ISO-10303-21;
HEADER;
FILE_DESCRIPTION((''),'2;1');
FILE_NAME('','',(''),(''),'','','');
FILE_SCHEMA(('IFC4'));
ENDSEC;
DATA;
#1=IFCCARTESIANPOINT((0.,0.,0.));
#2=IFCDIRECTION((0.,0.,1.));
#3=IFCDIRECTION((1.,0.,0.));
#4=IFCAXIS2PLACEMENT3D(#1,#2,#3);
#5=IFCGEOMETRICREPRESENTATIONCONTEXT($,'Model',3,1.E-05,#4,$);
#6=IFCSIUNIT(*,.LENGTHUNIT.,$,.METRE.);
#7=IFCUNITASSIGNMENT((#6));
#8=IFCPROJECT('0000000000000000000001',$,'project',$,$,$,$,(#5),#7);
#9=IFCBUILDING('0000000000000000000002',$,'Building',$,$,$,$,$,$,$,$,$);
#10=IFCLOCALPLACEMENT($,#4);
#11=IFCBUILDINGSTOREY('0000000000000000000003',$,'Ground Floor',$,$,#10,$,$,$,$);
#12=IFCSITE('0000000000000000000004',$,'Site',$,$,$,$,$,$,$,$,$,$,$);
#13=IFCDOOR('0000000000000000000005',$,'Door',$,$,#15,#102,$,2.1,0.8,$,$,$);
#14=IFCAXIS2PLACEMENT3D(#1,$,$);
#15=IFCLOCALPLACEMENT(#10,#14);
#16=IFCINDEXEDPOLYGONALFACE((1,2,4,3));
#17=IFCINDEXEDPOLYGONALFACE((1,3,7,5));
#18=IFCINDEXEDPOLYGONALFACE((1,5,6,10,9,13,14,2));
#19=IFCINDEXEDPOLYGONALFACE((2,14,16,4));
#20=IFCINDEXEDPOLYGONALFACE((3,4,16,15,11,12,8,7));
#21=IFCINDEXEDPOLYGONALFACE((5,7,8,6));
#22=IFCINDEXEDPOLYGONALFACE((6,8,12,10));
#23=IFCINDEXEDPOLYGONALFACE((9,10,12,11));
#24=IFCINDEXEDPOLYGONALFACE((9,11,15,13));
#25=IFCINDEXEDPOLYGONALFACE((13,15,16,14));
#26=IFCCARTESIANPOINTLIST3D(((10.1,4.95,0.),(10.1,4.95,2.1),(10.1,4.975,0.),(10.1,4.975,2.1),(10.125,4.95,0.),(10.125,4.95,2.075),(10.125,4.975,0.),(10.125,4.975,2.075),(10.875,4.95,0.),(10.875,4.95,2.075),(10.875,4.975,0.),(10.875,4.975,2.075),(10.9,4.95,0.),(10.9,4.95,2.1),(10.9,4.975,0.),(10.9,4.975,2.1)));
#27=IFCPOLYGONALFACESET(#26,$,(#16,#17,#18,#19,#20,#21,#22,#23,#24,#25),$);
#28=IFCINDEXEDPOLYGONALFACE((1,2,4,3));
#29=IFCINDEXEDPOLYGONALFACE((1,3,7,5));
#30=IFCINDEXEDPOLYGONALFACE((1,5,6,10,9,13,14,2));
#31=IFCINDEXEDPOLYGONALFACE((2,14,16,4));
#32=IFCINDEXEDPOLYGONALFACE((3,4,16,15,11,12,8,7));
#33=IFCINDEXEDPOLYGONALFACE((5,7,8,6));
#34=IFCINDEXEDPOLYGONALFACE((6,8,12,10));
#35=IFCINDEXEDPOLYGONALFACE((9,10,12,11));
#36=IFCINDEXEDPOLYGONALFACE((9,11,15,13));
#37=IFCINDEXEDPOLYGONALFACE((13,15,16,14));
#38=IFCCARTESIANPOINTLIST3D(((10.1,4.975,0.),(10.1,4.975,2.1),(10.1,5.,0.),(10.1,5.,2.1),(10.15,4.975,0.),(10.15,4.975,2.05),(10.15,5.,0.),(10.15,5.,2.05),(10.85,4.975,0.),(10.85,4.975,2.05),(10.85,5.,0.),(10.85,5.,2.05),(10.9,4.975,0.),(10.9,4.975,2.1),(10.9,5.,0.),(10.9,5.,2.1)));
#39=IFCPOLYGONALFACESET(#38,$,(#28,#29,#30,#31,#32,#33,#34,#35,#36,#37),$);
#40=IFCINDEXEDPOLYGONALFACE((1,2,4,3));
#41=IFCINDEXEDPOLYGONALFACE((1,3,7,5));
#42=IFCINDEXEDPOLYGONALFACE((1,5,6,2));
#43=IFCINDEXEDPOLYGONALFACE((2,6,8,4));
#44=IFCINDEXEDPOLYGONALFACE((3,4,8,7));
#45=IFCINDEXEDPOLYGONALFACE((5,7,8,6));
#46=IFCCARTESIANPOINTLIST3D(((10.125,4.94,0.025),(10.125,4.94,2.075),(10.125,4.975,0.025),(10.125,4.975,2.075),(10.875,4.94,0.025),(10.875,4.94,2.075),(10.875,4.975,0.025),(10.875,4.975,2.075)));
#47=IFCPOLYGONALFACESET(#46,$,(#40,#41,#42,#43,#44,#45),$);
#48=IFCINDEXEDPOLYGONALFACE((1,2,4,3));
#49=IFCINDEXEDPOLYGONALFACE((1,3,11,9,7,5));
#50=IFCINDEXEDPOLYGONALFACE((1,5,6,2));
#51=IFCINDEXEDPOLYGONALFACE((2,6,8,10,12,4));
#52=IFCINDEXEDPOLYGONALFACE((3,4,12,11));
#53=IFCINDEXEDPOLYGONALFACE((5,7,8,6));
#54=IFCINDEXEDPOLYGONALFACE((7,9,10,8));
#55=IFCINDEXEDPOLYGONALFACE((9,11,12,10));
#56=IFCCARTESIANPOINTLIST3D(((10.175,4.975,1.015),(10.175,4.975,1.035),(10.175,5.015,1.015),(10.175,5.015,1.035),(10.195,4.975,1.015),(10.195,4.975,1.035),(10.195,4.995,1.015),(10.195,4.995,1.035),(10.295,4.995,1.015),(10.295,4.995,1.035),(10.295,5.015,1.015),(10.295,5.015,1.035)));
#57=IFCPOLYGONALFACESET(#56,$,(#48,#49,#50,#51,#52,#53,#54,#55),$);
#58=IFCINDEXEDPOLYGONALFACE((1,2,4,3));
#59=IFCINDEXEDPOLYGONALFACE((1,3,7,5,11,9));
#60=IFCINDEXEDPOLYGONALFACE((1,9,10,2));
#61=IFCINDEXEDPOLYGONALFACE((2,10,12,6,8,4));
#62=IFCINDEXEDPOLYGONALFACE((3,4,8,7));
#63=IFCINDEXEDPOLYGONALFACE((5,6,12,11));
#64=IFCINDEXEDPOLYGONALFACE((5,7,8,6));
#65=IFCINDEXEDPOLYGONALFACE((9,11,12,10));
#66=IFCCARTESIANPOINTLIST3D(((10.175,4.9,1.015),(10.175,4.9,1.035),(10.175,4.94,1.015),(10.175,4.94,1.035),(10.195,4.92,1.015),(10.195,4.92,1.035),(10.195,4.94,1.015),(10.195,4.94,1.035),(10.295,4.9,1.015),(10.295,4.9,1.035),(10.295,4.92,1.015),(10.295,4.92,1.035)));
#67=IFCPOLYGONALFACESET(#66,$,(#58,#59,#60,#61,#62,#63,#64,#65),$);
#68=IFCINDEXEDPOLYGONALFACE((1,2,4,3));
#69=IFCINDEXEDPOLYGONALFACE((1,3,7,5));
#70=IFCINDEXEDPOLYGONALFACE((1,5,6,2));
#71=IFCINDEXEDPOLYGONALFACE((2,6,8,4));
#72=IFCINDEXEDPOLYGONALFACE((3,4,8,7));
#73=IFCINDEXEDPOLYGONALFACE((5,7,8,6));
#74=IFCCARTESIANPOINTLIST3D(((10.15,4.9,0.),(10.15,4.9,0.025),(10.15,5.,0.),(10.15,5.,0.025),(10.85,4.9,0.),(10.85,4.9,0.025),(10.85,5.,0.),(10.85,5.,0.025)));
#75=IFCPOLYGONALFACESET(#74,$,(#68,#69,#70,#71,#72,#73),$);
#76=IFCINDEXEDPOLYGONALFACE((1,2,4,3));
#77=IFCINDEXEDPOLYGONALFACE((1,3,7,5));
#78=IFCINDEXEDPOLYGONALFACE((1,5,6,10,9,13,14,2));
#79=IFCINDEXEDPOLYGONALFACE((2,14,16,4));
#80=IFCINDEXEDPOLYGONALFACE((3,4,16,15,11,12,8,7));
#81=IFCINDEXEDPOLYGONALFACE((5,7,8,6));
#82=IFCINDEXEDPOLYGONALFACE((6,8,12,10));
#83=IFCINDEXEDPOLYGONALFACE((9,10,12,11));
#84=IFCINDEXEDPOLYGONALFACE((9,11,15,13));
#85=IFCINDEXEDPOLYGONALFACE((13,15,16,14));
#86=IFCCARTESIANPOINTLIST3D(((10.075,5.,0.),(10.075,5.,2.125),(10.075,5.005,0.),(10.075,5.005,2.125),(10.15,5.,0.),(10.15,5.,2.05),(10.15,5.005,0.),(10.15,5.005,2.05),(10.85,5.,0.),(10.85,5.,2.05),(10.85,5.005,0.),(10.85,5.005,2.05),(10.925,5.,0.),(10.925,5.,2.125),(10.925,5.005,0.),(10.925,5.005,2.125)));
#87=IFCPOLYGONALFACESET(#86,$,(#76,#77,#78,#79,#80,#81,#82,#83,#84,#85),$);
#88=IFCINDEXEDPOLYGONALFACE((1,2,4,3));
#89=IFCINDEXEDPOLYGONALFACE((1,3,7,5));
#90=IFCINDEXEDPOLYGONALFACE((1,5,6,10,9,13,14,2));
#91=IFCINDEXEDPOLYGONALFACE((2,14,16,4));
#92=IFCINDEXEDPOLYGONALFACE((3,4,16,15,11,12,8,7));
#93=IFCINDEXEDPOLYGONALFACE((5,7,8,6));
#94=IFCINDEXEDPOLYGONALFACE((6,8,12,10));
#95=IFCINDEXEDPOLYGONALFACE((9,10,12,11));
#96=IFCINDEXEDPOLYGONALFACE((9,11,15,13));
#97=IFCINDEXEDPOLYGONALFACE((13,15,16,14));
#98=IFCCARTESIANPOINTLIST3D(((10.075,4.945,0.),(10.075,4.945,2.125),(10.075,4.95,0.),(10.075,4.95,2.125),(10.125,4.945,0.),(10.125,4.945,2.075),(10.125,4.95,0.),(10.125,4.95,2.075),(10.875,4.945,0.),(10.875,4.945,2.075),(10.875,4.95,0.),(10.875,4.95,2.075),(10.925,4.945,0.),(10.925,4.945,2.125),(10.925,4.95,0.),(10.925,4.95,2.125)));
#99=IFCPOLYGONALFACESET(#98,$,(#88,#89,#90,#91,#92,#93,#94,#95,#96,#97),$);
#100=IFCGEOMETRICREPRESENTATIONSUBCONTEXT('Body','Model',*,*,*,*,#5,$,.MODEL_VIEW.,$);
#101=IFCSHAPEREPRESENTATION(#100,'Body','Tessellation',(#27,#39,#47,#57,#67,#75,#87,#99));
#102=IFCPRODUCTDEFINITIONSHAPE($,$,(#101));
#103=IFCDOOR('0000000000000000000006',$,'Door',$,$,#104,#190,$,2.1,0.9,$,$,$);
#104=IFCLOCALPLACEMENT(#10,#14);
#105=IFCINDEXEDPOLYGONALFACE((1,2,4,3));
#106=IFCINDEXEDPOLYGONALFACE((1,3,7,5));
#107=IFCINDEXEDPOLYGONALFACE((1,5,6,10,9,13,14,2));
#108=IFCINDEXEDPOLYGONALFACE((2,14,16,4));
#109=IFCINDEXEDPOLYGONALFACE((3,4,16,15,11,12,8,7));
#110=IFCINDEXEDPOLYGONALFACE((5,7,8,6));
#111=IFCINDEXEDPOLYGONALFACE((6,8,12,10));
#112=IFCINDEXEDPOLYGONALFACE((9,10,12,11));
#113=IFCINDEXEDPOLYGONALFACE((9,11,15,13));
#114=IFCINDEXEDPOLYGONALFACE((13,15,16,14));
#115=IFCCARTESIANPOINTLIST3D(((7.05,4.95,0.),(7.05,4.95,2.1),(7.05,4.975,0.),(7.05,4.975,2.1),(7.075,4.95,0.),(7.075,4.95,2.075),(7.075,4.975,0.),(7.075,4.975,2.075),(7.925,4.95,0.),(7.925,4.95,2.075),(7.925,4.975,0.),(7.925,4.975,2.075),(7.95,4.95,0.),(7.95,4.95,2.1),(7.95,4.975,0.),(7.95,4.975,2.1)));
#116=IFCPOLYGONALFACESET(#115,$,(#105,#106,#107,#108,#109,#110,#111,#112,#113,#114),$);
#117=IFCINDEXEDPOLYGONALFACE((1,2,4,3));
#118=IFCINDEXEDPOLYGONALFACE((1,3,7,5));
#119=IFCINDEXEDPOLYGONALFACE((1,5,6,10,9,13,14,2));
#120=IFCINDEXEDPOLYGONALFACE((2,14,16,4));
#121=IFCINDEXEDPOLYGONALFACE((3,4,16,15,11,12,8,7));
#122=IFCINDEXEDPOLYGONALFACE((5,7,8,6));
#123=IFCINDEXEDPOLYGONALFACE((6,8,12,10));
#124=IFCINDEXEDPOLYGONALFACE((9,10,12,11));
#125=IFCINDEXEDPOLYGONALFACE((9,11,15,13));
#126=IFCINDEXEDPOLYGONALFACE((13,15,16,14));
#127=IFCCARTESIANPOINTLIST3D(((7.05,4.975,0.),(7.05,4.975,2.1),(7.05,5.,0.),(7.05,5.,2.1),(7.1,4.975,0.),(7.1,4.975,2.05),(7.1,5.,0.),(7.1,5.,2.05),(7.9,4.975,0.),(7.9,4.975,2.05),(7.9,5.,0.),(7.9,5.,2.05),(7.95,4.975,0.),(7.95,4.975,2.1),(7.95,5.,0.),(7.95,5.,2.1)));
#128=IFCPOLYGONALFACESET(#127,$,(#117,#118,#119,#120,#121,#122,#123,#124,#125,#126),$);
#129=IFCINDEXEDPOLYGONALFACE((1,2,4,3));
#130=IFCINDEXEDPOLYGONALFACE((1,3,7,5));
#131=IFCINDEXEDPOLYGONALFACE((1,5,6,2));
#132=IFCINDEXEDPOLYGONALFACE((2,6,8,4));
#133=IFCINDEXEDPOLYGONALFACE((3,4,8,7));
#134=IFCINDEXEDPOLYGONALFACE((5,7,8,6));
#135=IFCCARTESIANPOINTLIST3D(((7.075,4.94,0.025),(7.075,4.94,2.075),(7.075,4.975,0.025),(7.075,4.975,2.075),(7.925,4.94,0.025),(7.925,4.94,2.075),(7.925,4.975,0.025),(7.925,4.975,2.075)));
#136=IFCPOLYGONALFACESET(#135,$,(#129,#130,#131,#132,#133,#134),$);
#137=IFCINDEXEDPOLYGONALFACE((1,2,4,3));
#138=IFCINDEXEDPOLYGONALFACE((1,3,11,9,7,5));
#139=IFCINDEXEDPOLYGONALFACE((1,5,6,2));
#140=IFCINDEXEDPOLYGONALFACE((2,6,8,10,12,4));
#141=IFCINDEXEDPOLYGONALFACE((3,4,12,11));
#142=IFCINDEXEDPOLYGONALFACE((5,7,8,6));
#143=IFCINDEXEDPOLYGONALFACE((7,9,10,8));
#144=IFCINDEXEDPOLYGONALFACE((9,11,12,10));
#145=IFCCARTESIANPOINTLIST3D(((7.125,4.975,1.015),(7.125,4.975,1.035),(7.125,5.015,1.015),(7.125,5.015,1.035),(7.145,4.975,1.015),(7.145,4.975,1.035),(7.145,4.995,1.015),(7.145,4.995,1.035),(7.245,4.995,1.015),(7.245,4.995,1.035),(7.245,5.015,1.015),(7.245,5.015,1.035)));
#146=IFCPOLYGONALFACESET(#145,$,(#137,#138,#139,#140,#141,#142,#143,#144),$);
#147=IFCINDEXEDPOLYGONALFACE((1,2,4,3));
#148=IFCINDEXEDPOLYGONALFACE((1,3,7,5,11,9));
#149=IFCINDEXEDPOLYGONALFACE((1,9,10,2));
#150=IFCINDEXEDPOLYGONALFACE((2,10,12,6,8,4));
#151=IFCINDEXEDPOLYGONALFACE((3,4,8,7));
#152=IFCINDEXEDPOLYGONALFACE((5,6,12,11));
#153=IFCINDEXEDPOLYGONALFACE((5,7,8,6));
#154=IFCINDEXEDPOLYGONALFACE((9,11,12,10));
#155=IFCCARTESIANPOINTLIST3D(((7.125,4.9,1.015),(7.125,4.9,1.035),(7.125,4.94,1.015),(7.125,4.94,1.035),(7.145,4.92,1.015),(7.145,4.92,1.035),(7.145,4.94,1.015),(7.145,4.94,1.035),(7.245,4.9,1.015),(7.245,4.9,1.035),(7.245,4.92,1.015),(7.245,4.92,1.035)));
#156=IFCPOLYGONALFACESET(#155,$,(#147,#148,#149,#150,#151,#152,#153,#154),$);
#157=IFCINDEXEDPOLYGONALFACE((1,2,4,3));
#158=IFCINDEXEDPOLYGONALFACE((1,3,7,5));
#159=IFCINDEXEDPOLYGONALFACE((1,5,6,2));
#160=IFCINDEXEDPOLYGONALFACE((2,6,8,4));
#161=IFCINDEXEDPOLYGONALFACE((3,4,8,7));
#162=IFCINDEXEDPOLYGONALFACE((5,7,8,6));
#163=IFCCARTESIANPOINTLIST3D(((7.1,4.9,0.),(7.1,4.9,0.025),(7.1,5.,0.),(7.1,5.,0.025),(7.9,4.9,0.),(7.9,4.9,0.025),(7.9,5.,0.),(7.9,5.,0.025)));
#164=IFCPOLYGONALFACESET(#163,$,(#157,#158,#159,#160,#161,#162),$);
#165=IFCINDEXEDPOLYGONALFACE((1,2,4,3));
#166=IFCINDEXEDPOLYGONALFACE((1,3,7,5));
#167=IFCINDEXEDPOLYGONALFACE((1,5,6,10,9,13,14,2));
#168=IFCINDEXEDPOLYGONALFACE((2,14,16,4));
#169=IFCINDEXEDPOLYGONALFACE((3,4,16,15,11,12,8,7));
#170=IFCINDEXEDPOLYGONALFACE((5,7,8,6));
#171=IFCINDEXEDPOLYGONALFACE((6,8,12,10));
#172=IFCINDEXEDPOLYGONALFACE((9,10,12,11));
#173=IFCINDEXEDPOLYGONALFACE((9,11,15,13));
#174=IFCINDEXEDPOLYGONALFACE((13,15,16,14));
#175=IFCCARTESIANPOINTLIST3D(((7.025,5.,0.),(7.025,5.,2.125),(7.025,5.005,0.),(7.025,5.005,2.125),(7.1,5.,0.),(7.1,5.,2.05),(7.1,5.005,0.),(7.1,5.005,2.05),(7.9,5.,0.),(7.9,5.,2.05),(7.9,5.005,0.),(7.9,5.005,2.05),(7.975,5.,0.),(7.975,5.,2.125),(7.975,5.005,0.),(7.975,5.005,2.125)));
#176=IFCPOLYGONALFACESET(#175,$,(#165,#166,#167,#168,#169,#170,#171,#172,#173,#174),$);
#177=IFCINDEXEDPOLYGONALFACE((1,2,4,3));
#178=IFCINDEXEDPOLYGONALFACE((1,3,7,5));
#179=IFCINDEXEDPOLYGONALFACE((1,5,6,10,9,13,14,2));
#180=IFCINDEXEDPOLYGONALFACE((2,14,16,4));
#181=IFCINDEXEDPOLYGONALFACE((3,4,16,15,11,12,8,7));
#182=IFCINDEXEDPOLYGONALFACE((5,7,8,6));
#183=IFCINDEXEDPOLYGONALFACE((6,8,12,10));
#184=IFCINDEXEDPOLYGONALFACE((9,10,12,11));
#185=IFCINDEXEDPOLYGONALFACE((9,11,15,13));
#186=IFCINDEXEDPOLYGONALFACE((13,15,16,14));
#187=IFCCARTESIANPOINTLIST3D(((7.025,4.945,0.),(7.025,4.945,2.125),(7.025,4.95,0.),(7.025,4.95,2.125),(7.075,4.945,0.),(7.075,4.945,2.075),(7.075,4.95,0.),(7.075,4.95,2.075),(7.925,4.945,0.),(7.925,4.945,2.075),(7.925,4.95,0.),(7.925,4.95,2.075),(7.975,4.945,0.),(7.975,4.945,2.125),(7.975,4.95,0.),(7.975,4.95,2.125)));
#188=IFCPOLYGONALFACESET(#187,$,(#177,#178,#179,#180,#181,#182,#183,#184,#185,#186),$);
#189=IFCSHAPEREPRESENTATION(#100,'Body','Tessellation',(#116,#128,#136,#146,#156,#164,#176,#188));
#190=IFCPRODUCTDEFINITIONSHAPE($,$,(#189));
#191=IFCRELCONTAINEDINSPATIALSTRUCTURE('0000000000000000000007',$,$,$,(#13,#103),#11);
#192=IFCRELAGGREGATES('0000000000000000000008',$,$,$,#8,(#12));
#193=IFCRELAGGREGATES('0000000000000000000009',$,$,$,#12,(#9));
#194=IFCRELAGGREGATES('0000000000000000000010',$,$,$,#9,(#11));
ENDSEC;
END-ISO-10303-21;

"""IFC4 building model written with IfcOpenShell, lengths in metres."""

from ifc_helpers import new_model, si_unit, frame, origin_with_axes, place, context, subcontext, project, spatial, line, indexed_curve, outline, extrude, element, save


model = new_model("IFC4")

# Units and contexts
model_context = context("Model", 3, precision=1e-05, world=origin_with_axes())
body_context = subcontext(model_context, "Body", "Model", "MODEL_VIEW")
ifc_project = project(units=[si_unit("LENGTHUNIT", "METRE")], contexts=[model_context])

# Site, building, storey
site = spatial("IfcSite", under=ifc_project, Name="Site")
building = spatial("IfcBuilding", under=site, Name="Building")
storey_placement = place(None, origin_with_axes())
storey = spatial("IfcBuildingStorey", under=building, at=storey_placement, Name="Ground Floor")

# Doors
door_1_placement = place(storey_placement, frame((10.9, 5.0, 0.0), z_axis=(0.0, 0.0, 1.0), x_axis=(-1.0, 0.0, 0.0)))
element("IfcDoor", 1, at=door_1_placement, inside=storey, Name="Door", OverallHeight=2.1, OverallWidth=0.8, context=body_context, shape_type="SweptSolid", body=[
    extrude(outline(indexed_curve([(0.0, 0.0), (0.0, 2.1), (0.8, 2.1), (0.8, 0.0), (0.775, 0.0), (0.775, 2.075), (0.025, 2.075), (0.025, 0.0)], segments=[line(1, 2, 3, 4, 5, 6, 7, 8, 1)])), frame((0.0, 0.025, 0.0), z_axis=(0.0, -1.0, 0.0), x_axis=(1.0, 0.0, 0.0)), (0.0, 0.0, -1.0), 0.025),
    extrude(outline(indexed_curve([(0.0, 0.0), (0.0, 2.1), (0.8, 2.1), (0.8, 0.0), (0.75, 0.0), (0.75, 2.05), (0.05, 2.05), (0.05, 0.0)], segments=[line(1, 2, 3, 4, 5, 6, 7, 8, 1)])), frame((0.0, 0.0, 0.0), z_axis=(0.0, -1.0, 0.0), x_axis=(1.0, 0.0, 0.0)), (0.0, 0.0, -1.0), 0.025),
    extrude(outline(indexed_curve([(0.0, 0.0), (0.75, 0.0), (0.75, 0.035), (0.0, 0.035)], segments=[line(1, 2, 3, 4, 1)])), frame((0.025, 0.025, 0.025), z_axis=(0.0, 0.0, 1.0), x_axis=(1.0, 0.0, 0.0)), (0.0, 0.0, 1.0), 2.05),
    extrude(outline(indexed_curve([(0.0, 0.0), (0.0, -0.04), (-0.12, -0.04), (-0.12, -0.02), (-0.02, -0.02), (-0.02, 0.0)], segments=[line(1, 2, 3, 4, 5, 6, 1)])), frame((0.725, 0.025, 1.015), z_axis=(0.0, 0.0, 1.0), x_axis=(1.0, 0.0, 0.0)), (0.0, 0.0, 1.0), 0.02),
    extrude(outline(indexed_curve([(0.0, 0.0), (0.0, 0.04), (-0.12, 0.04), (-0.12, 0.02), (-0.02, 0.02), (-0.02, 0.0)], segments=[line(1, 2, 3, 4, 5, 6, 1)])), frame((0.725, 0.06, 1.015), z_axis=(0.0, 0.0, 1.0), x_axis=(1.0, 0.0, 0.0)), (0.0, 0.0, 1.0), 0.02),
    extrude(outline(indexed_curve([(0.0, 0.0), (0.7, 0.0), (0.7, 0.1), (0.0, 0.1)], segments=[line(1, 2, 3, 4, 1)])), frame((0.05, 0.0, 0.0), z_axis=(0.0, 0.0, 1.0), x_axis=(1.0, 0.0, 0.0)), (0.0, 0.0, 1.0), 0.025),
    extrude(outline(indexed_curve([(0.0, 0.0), (0.0, 2.125), (0.85, 2.125), (0.85, 0.0), (0.775, 0.0), (0.775, 2.05), (0.075, 2.05), (0.075, 0.0)], segments=[line(1, 2, 3, 4, 5, 6, 7, 8, 1)])), frame((-0.025, -0.005, 0.0), z_axis=(0.0, -1.0, 0.0), x_axis=(1.0, 0.0, 0.0)), (0.0, 0.0, -1.0), 0.005),
    extrude(outline(indexed_curve([(0.0, 0.0), (0.0, 2.125), (0.85, 2.125), (0.85, 0.0), (0.8, 0.0), (0.8, 2.075), (0.05, 2.075), (0.05, 0.0)], segments=[line(1, 2, 3, 4, 5, 6, 7, 8, 1)])), frame((-0.025, 0.05, 0.0), z_axis=(0.0, -1.0, 0.0), x_axis=(1.0, 0.0, 0.0)), (0.0, 0.0, -1.0), 0.005),
])
door_2_placement = place(storey_placement, frame((7.95, 5.0, 0.0), z_axis=(0.0, 0.0, 1.0), x_axis=(-1.0, 0.0, 0.0)))
element("IfcDoor", 2, at=door_2_placement, inside=storey, Name="Door", OverallHeight=2.1, OverallWidth=0.9, context=body_context, shape_type="SweptSolid", body=[
    extrude(outline(indexed_curve([(0.0, 0.0), (0.0, 2.1), (0.9, 2.1), (0.9, 0.0), (0.875, 0.0), (0.875, 2.075), (0.025, 2.075), (0.025, 0.0)], segments=[line(1, 2, 3, 4, 5, 6, 7, 8, 1)])), frame((0.0, 0.025, 0.0), z_axis=(0.0, -1.0, 0.0), x_axis=(1.0, 0.0, 0.0)), (0.0, 0.0, -1.0), 0.025),
    extrude(outline(indexed_curve([(0.0, 0.0), (0.0, 2.1), (0.9, 2.1), (0.9, 0.0), (0.85, 0.0), (0.85, 2.05), (0.05, 2.05), (0.05, 0.0)], segments=[line(1, 2, 3, 4, 5, 6, 7, 8, 1)])), frame((0.0, 0.0, 0.0), z_axis=(0.0, -1.0, 0.0), x_axis=(1.0, 0.0, 0.0)), (0.0, 0.0, -1.0), 0.025),
    extrude(outline(indexed_curve([(0.0, 0.0), (0.85, 0.0), (0.85, 0.035), (0.0, 0.035)], segments=[line(1, 2, 3, 4, 1)])), frame((0.025, 0.025, 0.025), z_axis=(0.0, 0.0, 1.0), x_axis=(1.0, 0.0, 0.0)), (0.0, 0.0, 1.0), 2.05),
    extrude(outline(indexed_curve([(0.0, 0.0), (0.0, -0.04), (-0.12, -0.04), (-0.12, -0.02), (-0.02, -0.02), (-0.02, 0.0)], segments=[line(1, 2, 3, 4, 5, 6, 1)])), frame((0.825, 0.025, 1.015), z_axis=(0.0, 0.0, 1.0), x_axis=(1.0, 0.0, 0.0)), (0.0, 0.0, 1.0), 0.02),
    extrude(outline(indexed_curve([(0.0, 0.0), (0.0, 0.04), (-0.12, 0.04), (-0.12, 0.02), (-0.02, 0.02), (-0.02, 0.0)], segments=[line(1, 2, 3, 4, 5, 6, 1)])), frame((0.825, 0.06, 1.015), z_axis=(0.0, 0.0, 1.0), x_axis=(1.0, 0.0, 0.0)), (0.0, 0.0, 1.0), 0.02),
    extrude(outline(indexed_curve([(0.0, 0.0), (0.8, 0.0), (0.8, 0.1), (0.0, 0.1)], segments=[line(1, 2, 3, 4, 1)])), frame((0.05, 0.0, 0.0), z_axis=(0.0, 0.0, 1.0), x_axis=(1.0, 0.0, 0.0)), (0.0, 0.0, 1.0), 0.025),
    extrude(outline(indexed_curve([(0.0, 0.0), (0.0, 2.125), (0.95, 2.125), (0.95, 0.0), (0.875, 0.0), (0.875, 2.05), (0.075, 2.05), (0.075, 0.0)], segments=[line(1, 2, 3, 4, 5, 6, 7, 8, 1)])), frame((-0.025, -0.005, 0.0), z_axis=(0.0, -1.0, 0.0), x_axis=(1.0, 0.0, 0.0)), (0.0, 0.0, -1.0), 0.005),
    extrude(outline(indexed_curve([(0.0, 0.0), (0.0, 2.125), (0.95, 2.125), (0.95, 0.0), (0.9, 0.0), (0.9, 2.075), (0.05, 2.075), (0.05, 0.0)], segments=[line(1, 2, 3, 4, 5, 6, 7, 8, 1)])), frame((-0.025, 0.05, 0.0), z_axis=(0.0, -1.0, 0.0), x_axis=(1.0, 0.0, 0.0)), (0.0, 0.0, -1.0), 0.005),
])

save(model, "model.ifc")
